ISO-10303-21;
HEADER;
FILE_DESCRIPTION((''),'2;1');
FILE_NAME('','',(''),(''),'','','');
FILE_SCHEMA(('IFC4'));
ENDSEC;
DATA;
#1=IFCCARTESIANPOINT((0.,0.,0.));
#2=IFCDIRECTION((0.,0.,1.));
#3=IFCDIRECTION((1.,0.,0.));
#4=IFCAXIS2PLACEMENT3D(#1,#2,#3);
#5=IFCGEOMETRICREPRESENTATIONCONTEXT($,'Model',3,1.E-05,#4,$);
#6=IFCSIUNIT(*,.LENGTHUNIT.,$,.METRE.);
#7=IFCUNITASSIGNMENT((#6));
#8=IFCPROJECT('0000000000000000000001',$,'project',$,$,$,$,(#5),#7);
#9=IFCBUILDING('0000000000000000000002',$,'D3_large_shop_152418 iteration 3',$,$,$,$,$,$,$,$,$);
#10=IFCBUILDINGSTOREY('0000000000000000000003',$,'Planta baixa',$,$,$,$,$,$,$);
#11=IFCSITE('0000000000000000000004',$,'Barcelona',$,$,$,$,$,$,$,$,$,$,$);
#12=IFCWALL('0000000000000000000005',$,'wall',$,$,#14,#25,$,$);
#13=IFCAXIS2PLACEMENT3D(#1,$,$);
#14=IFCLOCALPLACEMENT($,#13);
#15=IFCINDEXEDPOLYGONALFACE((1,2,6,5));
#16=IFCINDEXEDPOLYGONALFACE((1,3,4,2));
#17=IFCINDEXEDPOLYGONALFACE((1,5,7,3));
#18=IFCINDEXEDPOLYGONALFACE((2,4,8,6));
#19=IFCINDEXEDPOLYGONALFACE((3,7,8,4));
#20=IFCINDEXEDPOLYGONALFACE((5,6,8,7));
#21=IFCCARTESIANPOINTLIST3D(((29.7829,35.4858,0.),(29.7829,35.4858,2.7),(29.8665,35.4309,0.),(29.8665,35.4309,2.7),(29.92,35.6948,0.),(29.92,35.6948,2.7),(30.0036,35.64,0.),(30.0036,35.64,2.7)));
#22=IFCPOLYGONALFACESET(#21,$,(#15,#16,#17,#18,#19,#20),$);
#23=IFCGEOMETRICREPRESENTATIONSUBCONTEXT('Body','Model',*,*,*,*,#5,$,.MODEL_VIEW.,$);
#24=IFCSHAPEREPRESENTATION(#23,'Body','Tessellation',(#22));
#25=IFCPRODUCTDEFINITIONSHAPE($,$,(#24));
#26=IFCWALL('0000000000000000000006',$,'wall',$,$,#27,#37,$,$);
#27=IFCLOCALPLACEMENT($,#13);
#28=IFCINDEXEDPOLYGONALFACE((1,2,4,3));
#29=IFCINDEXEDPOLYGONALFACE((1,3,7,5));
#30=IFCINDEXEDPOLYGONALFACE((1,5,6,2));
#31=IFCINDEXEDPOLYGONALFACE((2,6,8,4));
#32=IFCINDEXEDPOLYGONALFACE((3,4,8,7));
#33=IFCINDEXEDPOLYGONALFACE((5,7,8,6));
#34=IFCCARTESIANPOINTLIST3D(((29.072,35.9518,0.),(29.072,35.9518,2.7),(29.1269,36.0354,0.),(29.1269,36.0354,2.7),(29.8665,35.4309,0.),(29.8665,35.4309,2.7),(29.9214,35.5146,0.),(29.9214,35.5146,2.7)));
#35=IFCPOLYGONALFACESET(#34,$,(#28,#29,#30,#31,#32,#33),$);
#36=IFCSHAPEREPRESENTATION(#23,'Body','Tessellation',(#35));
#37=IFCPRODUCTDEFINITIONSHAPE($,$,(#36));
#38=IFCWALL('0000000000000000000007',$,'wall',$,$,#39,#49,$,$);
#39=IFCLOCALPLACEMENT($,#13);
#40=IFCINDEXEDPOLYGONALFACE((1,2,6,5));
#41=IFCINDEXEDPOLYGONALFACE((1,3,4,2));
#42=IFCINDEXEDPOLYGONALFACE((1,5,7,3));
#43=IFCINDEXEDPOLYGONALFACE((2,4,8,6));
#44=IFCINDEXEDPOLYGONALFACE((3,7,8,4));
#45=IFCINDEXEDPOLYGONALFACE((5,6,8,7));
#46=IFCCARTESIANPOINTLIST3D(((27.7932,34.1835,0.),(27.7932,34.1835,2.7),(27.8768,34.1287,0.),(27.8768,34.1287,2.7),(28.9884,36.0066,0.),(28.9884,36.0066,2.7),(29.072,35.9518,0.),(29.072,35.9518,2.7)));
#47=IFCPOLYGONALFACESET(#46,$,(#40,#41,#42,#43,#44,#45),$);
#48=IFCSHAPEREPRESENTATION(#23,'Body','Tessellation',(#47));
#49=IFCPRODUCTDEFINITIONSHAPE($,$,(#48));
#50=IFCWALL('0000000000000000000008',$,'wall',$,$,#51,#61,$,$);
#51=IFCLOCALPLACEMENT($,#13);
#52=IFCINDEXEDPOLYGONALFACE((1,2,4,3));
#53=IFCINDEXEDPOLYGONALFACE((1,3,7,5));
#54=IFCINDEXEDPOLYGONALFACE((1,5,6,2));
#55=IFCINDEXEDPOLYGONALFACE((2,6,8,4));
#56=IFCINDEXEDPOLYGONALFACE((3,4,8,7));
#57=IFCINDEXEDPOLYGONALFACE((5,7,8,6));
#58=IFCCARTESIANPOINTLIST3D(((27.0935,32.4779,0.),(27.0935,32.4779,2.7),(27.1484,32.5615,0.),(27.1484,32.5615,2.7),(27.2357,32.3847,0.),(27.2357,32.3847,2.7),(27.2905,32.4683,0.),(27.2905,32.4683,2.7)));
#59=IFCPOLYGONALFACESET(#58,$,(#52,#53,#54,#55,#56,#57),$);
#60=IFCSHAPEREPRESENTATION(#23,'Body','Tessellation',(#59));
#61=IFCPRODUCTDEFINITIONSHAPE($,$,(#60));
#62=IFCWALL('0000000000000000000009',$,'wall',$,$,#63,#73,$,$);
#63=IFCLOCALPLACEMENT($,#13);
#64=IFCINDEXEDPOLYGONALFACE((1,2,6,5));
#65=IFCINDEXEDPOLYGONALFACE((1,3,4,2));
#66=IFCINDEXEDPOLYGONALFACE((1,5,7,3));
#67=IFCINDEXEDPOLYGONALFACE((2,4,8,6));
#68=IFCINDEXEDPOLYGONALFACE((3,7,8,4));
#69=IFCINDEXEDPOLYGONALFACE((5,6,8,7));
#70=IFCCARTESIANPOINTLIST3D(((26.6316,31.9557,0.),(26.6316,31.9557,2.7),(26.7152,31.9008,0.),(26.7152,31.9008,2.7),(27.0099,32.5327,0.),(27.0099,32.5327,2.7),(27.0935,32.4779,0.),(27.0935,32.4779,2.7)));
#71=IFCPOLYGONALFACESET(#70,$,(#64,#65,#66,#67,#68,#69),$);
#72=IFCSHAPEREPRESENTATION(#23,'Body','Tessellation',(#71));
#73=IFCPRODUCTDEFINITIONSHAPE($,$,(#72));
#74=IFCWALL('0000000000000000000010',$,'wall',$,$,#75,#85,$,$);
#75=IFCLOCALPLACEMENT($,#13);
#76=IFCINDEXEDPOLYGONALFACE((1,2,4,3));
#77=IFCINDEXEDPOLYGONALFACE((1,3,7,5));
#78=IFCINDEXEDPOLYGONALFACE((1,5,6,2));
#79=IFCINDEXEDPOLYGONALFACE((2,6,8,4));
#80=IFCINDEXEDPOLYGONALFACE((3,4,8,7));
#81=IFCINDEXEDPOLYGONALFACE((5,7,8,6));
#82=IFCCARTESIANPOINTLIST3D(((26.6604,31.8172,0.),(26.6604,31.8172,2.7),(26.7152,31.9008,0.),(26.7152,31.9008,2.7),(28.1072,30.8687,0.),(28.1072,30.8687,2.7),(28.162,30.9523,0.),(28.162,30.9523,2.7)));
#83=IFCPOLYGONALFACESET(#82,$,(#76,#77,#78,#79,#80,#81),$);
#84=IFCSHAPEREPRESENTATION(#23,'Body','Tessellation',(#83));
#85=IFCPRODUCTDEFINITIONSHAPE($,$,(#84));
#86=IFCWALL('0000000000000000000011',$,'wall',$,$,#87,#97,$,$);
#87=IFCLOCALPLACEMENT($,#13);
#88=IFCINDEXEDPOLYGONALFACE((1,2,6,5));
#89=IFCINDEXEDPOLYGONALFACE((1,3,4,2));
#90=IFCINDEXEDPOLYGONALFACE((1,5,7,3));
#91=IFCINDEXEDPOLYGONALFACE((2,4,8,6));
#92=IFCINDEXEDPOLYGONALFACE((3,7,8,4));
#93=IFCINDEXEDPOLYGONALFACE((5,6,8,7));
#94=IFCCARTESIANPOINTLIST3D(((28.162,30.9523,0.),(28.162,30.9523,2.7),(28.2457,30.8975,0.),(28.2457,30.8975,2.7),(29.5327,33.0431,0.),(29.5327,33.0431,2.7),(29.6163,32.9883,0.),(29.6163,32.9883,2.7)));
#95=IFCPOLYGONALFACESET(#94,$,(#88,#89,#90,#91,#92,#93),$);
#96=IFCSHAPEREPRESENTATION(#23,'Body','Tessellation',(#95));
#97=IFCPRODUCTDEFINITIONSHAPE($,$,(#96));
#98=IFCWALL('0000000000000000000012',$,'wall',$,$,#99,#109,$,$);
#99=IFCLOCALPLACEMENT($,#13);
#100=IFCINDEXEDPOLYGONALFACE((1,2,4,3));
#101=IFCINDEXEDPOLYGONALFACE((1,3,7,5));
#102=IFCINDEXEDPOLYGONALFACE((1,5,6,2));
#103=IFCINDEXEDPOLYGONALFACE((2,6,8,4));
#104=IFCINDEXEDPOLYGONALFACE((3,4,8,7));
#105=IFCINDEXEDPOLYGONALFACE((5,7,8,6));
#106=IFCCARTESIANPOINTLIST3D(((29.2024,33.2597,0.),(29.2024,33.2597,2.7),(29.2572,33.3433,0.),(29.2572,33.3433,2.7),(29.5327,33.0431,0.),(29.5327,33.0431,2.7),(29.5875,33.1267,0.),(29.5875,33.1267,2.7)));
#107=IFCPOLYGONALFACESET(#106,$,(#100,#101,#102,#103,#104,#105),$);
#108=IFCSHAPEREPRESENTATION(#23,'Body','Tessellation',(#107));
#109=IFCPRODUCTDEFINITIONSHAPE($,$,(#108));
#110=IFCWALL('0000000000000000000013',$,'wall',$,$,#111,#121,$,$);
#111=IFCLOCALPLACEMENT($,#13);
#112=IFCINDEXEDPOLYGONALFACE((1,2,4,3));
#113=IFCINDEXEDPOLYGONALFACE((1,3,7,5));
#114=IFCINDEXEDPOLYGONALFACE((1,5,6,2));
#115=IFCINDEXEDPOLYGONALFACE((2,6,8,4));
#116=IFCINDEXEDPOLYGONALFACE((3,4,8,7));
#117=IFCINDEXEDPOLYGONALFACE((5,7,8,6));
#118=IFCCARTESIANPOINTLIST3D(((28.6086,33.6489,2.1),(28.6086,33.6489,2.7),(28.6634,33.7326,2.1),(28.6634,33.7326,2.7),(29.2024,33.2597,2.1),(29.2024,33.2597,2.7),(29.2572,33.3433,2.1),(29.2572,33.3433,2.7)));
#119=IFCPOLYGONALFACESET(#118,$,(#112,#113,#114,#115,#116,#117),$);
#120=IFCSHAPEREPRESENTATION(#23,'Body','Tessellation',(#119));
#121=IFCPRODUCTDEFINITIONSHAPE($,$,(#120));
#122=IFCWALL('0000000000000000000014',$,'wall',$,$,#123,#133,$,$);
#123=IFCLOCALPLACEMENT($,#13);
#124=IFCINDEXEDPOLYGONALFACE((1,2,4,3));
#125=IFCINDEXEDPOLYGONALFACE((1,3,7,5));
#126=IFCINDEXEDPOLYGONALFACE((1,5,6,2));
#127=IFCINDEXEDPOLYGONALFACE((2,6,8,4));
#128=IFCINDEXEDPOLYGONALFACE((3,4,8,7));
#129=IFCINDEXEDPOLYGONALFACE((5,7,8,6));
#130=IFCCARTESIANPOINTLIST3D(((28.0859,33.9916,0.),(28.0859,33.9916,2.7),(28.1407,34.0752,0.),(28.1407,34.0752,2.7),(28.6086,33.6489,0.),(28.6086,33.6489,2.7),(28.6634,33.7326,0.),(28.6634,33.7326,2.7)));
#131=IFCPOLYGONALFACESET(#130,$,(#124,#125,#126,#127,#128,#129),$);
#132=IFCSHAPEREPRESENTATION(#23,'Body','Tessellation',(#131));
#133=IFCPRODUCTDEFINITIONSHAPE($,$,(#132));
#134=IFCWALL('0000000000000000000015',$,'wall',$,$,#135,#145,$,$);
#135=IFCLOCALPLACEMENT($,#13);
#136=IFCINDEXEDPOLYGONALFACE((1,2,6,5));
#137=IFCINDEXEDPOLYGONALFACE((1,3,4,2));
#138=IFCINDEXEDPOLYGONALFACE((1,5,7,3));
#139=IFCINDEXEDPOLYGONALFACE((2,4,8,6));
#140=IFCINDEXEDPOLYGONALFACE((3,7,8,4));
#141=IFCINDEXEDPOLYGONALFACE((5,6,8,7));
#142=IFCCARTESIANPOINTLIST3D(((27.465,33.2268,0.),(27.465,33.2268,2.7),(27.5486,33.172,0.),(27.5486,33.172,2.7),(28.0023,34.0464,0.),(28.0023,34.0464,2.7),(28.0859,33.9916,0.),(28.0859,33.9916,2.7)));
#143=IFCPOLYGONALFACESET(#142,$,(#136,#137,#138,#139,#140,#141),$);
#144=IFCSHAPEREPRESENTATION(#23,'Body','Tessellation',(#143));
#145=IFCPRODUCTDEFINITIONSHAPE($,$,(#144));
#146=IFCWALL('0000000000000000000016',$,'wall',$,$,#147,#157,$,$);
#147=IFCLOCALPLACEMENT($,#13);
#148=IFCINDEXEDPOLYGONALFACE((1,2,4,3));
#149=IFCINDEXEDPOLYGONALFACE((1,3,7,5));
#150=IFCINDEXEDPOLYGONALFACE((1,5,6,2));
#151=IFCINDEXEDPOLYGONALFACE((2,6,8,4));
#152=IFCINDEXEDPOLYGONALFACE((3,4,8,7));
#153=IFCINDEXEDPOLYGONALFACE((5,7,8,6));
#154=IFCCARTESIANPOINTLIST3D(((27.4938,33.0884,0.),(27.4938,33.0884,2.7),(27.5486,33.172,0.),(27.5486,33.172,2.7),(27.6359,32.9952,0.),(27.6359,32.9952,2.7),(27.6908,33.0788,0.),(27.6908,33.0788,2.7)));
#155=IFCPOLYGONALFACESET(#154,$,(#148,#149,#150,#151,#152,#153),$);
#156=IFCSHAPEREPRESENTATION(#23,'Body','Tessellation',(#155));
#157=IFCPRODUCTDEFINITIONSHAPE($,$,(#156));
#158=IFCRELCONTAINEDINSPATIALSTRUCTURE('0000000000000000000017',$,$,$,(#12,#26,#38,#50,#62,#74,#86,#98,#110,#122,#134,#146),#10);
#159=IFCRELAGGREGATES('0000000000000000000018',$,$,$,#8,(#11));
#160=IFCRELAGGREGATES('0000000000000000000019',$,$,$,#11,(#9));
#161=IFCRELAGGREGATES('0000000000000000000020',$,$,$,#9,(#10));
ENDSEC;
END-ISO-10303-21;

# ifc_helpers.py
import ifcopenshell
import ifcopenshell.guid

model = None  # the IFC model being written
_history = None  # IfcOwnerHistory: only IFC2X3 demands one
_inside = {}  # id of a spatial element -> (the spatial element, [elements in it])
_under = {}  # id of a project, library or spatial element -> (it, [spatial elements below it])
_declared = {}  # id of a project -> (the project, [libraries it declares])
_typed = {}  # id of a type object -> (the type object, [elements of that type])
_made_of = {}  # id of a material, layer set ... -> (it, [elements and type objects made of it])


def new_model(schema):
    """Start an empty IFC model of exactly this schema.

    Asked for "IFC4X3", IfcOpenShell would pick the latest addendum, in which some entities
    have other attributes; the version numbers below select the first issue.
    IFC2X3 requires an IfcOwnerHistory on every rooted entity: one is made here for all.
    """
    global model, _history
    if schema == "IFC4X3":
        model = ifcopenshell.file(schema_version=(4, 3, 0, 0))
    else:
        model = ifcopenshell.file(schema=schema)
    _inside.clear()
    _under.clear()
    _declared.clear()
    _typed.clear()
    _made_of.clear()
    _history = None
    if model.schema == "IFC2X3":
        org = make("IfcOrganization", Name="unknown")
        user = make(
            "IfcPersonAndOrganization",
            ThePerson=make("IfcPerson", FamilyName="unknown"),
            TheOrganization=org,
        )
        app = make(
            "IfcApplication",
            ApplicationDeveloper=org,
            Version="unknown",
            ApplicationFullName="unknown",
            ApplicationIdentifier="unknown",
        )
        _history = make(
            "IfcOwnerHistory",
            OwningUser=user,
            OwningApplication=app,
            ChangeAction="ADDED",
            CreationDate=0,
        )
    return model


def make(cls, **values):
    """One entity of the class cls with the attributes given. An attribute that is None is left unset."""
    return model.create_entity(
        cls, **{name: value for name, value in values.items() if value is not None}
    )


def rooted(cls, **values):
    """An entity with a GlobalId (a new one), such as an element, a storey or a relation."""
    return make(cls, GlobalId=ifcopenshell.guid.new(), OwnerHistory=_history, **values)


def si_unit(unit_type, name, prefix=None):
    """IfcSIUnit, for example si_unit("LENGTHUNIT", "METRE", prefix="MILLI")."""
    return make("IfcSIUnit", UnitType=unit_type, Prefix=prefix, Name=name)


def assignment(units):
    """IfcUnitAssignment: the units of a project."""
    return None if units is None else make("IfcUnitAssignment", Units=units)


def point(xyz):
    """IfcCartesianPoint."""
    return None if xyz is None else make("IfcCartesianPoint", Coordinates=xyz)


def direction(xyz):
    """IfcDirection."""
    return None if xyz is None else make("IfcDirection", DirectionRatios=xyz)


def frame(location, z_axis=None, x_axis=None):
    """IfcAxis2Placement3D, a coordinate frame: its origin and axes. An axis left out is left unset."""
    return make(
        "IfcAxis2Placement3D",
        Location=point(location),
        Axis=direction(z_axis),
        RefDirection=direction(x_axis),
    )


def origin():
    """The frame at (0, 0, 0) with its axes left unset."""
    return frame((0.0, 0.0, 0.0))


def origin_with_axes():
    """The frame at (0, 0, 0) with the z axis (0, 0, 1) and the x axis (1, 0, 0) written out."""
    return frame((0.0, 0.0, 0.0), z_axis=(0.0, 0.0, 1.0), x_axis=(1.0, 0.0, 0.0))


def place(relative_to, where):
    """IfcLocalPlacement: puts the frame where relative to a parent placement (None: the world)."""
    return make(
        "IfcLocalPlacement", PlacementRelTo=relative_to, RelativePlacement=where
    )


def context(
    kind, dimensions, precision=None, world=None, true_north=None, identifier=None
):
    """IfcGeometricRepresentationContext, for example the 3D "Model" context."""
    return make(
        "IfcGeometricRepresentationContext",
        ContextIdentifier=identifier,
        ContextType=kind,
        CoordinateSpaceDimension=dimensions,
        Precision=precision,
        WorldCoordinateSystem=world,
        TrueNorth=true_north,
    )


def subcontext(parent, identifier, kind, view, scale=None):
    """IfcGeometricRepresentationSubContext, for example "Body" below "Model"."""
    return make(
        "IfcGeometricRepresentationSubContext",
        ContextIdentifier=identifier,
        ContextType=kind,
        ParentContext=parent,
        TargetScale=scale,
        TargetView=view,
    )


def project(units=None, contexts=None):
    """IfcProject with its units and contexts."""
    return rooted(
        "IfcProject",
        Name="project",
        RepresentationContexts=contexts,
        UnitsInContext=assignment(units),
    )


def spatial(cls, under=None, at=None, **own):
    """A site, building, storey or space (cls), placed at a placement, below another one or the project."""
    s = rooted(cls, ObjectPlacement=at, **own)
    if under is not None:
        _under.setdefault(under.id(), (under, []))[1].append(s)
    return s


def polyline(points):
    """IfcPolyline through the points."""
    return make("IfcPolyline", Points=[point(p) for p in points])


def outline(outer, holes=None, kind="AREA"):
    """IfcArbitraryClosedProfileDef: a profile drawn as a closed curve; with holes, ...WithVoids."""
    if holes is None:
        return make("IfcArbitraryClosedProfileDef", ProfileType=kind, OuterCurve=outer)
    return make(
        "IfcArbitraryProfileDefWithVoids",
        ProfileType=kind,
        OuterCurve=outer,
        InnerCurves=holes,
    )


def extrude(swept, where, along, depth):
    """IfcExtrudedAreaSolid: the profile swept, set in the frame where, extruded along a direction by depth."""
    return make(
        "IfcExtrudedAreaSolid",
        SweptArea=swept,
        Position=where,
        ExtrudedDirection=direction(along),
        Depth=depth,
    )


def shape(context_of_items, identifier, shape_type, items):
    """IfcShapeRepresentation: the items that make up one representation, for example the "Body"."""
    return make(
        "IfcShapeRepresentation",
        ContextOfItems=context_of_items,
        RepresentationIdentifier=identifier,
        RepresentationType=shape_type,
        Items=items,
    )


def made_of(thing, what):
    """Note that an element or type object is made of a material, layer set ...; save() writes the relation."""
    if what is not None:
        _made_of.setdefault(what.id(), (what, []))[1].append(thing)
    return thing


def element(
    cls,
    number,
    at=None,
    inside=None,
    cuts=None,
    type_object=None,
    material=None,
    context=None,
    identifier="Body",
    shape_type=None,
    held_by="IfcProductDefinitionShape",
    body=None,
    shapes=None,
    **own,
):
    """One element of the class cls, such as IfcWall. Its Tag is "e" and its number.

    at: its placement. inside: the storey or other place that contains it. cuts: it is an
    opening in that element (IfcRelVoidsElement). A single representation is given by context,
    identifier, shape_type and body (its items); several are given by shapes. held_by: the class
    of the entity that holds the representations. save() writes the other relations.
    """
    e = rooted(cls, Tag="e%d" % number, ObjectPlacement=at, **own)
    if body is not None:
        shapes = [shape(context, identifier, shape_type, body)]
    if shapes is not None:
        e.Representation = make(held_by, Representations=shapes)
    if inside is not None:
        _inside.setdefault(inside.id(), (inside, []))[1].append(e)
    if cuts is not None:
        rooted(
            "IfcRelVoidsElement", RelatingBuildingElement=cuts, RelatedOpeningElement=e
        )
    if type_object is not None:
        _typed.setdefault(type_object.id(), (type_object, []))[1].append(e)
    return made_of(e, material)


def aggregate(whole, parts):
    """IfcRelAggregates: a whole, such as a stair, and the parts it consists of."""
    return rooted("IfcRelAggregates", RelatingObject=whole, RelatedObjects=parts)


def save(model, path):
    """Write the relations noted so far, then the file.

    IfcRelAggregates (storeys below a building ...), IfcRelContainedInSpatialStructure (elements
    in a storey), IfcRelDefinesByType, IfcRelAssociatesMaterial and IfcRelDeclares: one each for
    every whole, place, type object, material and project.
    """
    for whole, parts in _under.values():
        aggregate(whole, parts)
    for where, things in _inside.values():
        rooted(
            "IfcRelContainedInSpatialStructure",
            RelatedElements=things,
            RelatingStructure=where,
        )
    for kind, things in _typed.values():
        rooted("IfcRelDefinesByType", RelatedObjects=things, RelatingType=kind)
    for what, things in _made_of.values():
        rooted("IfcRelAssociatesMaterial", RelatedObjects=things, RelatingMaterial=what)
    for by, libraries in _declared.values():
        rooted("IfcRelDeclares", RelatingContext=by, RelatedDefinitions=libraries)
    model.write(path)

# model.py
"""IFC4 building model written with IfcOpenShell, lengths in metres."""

from ifc_helpers import new_model, si_unit, frame, origin, origin_with_axes, place, context, subcontext, project, spatial, polyline, outline, extrude, element, save


model = new_model("IFC4")

# Units and contexts
model_context = context("Model", 3, precision=1e-05, world=origin_with_axes())
body_context = subcontext(model_context, "Body", "Model", "MODEL_VIEW")
ifc_project = project(units=[si_unit("LENGTHUNIT", "METRE")], contexts=[model_context])

# Site, building, storey
site = spatial("IfcSite", under=ifc_project, Name="Barcelona")
building = spatial("IfcBuilding", under=site, Name="D3_large_shop_152418 iteration 3")
storey = spatial("IfcBuildingStorey", under=building, Name="Planta baixa")

# Walls
wall_1_placement = place(None, origin_with_axes())
element("IfcWall", 1, at=wall_1_placement, inside=storey, Name="wall", context=body_context, shape_type="SweptSolid", body=[
    extrude(outline(polyline([(30.0036, 35.64), (29.8665, 35.4309), (29.7829, 35.4858), (29.92, 35.6948), (30.0036, 35.64)])), origin(), (0.0, 0.0, 1.0), 2.7),
])
wall_2_placement = place(None, origin_with_axes())
element("IfcWall", 2, at=wall_2_placement, inside=storey, Name="wall", context=body_context, shape_type="SweptSolid", body=[
    extrude(outline(polyline([(29.8665, 35.4309), (29.072, 35.9518), (29.1269, 36.0354), (29.9214, 35.5146), (29.8665, 35.4309)])), origin(), (0.0, 0.0, 1.0), 2.7),
])
wall_3_placement = place(None, origin_with_axes())
element("IfcWall", 3, at=wall_3_placement, inside=storey, Name="wall", context=body_context, shape_type="SweptSolid", body=[
    extrude(outline(polyline([(29.072, 35.9518), (27.8768, 34.1287), (27.7932, 34.1835), (28.9884, 36.0066), (29.072, 35.9518)])), origin(), (0.0, 0.0, 1.0), 2.7),
])
wall_4_placement = place(None, origin_with_axes())
element("IfcWall", 4, at=wall_4_placement, inside=storey, Name="wall", context=body_context, shape_type="SweptSolid", body=[
    extrude(outline(polyline([(27.2357, 32.3847), (27.0935, 32.4779), (27.1484, 32.5615), (27.2905, 32.4683), (27.2357, 32.3847)])), origin(), (0.0, 0.0, 1.0), 2.7),
])
wall_5_placement = place(None, origin_with_axes())
element("IfcWall", 5, at=wall_5_placement, inside=storey, Name="wall", context=body_context, shape_type="SweptSolid", body=[
    extrude(outline(polyline([(27.0935, 32.4779), (26.7152, 31.9008), (26.6316, 31.9557), (27.0099, 32.5327), (27.0935, 32.4779)])), origin(), (0.0, 0.0, 1.0), 2.7),
])
wall_6_placement = place(None, origin_with_axes())
element("IfcWall", 6, at=wall_6_placement, inside=storey, Name="wall", context=body_context, shape_type="SweptSolid", body=[
    extrude(outline(polyline([(26.7152, 31.9008), (28.162, 30.9523), (28.1072, 30.8687), (26.6604, 31.8172), (26.7152, 31.9008)])), origin(), (0.0, 0.0, 1.0), 2.7),
])
wall_7_placement = place(None, origin_with_axes())
element("IfcWall", 7, at=wall_7_placement, inside=storey, Name="wall", context=body_context, shape_type="SweptSolid", body=[
    extrude(outline(polyline([(28.162, 30.9523), (29.5327, 33.0431), (29.6163, 32.9883), (28.2457, 30.8975), (28.162, 30.9523)])), origin(), (0.0, 0.0, 1.0), 2.7),
])
wall_8_placement = place(None, origin_with_axes())
element("IfcWall", 8, at=wall_8_placement, inside=storey, Name="wall", context=body_context, shape_type="SweptSolid", body=[
    extrude(outline(polyline([(29.5327, 33.0431), (29.2024, 33.2597), (29.2572, 33.3433), (29.5875, 33.1267), (29.5327, 33.0431)])), origin(), (0.0, 0.0, 1.0), 2.7),
])
wall_9_placement = place(None, origin_with_axes())
element("IfcWall", 9, at=wall_9_placement, inside=storey, Name="wall", context=body_context, shape_type="SweptSolid", body=[
    extrude(outline(polyline([(29.2024, 33.2597), (28.6086, 33.6489), (28.6634, 33.7326), (29.2572, 33.3433), (29.2024, 33.2597)])), frame((0.0, 0.0, 2.1)), (0.0, 0.0, 1.0), 0.6),
])
wall_10_placement = place(None, origin_with_axes())
element("IfcWall", 10, at=wall_10_placement, inside=storey, Name="wall", context=body_context, shape_type="SweptSolid", body=[
    extrude(outline(polyline([(28.6086, 33.6489), (28.0859, 33.9916), (28.1407, 34.0752), (28.6634, 33.7326), (28.6086, 33.6489)])), origin(), (0.0, 0.0, 1.0), 2.7),
])
wall_11_placement = place(None, origin_with_axes())
element("IfcWall", 11, at=wall_11_placement, inside=storey, Name="wall", context=body_context, shape_type="SweptSolid", body=[
    extrude(outline(polyline([(28.0859, 33.9916), (27.5486, 33.172), (27.465, 33.2268), (28.0023, 34.0464), (28.0859, 33.9916)])), origin(), (0.0, 0.0, 1.0), 2.7),
])
wall_12_placement = place(None, origin_with_axes())
element("IfcWall", 12, at=wall_12_placement, inside=storey, Name="wall", context=body_context, shape_type="SweptSolid", body=[
    extrude(outline(polyline([(27.5486, 33.172), (27.6908, 33.0788), (27.6359, 32.9952), (27.4938, 33.0884), (27.5486, 33.172)])), origin(), (0.0, 0.0, 1.0), 2.7),
])

save(model, "model.ifc")
